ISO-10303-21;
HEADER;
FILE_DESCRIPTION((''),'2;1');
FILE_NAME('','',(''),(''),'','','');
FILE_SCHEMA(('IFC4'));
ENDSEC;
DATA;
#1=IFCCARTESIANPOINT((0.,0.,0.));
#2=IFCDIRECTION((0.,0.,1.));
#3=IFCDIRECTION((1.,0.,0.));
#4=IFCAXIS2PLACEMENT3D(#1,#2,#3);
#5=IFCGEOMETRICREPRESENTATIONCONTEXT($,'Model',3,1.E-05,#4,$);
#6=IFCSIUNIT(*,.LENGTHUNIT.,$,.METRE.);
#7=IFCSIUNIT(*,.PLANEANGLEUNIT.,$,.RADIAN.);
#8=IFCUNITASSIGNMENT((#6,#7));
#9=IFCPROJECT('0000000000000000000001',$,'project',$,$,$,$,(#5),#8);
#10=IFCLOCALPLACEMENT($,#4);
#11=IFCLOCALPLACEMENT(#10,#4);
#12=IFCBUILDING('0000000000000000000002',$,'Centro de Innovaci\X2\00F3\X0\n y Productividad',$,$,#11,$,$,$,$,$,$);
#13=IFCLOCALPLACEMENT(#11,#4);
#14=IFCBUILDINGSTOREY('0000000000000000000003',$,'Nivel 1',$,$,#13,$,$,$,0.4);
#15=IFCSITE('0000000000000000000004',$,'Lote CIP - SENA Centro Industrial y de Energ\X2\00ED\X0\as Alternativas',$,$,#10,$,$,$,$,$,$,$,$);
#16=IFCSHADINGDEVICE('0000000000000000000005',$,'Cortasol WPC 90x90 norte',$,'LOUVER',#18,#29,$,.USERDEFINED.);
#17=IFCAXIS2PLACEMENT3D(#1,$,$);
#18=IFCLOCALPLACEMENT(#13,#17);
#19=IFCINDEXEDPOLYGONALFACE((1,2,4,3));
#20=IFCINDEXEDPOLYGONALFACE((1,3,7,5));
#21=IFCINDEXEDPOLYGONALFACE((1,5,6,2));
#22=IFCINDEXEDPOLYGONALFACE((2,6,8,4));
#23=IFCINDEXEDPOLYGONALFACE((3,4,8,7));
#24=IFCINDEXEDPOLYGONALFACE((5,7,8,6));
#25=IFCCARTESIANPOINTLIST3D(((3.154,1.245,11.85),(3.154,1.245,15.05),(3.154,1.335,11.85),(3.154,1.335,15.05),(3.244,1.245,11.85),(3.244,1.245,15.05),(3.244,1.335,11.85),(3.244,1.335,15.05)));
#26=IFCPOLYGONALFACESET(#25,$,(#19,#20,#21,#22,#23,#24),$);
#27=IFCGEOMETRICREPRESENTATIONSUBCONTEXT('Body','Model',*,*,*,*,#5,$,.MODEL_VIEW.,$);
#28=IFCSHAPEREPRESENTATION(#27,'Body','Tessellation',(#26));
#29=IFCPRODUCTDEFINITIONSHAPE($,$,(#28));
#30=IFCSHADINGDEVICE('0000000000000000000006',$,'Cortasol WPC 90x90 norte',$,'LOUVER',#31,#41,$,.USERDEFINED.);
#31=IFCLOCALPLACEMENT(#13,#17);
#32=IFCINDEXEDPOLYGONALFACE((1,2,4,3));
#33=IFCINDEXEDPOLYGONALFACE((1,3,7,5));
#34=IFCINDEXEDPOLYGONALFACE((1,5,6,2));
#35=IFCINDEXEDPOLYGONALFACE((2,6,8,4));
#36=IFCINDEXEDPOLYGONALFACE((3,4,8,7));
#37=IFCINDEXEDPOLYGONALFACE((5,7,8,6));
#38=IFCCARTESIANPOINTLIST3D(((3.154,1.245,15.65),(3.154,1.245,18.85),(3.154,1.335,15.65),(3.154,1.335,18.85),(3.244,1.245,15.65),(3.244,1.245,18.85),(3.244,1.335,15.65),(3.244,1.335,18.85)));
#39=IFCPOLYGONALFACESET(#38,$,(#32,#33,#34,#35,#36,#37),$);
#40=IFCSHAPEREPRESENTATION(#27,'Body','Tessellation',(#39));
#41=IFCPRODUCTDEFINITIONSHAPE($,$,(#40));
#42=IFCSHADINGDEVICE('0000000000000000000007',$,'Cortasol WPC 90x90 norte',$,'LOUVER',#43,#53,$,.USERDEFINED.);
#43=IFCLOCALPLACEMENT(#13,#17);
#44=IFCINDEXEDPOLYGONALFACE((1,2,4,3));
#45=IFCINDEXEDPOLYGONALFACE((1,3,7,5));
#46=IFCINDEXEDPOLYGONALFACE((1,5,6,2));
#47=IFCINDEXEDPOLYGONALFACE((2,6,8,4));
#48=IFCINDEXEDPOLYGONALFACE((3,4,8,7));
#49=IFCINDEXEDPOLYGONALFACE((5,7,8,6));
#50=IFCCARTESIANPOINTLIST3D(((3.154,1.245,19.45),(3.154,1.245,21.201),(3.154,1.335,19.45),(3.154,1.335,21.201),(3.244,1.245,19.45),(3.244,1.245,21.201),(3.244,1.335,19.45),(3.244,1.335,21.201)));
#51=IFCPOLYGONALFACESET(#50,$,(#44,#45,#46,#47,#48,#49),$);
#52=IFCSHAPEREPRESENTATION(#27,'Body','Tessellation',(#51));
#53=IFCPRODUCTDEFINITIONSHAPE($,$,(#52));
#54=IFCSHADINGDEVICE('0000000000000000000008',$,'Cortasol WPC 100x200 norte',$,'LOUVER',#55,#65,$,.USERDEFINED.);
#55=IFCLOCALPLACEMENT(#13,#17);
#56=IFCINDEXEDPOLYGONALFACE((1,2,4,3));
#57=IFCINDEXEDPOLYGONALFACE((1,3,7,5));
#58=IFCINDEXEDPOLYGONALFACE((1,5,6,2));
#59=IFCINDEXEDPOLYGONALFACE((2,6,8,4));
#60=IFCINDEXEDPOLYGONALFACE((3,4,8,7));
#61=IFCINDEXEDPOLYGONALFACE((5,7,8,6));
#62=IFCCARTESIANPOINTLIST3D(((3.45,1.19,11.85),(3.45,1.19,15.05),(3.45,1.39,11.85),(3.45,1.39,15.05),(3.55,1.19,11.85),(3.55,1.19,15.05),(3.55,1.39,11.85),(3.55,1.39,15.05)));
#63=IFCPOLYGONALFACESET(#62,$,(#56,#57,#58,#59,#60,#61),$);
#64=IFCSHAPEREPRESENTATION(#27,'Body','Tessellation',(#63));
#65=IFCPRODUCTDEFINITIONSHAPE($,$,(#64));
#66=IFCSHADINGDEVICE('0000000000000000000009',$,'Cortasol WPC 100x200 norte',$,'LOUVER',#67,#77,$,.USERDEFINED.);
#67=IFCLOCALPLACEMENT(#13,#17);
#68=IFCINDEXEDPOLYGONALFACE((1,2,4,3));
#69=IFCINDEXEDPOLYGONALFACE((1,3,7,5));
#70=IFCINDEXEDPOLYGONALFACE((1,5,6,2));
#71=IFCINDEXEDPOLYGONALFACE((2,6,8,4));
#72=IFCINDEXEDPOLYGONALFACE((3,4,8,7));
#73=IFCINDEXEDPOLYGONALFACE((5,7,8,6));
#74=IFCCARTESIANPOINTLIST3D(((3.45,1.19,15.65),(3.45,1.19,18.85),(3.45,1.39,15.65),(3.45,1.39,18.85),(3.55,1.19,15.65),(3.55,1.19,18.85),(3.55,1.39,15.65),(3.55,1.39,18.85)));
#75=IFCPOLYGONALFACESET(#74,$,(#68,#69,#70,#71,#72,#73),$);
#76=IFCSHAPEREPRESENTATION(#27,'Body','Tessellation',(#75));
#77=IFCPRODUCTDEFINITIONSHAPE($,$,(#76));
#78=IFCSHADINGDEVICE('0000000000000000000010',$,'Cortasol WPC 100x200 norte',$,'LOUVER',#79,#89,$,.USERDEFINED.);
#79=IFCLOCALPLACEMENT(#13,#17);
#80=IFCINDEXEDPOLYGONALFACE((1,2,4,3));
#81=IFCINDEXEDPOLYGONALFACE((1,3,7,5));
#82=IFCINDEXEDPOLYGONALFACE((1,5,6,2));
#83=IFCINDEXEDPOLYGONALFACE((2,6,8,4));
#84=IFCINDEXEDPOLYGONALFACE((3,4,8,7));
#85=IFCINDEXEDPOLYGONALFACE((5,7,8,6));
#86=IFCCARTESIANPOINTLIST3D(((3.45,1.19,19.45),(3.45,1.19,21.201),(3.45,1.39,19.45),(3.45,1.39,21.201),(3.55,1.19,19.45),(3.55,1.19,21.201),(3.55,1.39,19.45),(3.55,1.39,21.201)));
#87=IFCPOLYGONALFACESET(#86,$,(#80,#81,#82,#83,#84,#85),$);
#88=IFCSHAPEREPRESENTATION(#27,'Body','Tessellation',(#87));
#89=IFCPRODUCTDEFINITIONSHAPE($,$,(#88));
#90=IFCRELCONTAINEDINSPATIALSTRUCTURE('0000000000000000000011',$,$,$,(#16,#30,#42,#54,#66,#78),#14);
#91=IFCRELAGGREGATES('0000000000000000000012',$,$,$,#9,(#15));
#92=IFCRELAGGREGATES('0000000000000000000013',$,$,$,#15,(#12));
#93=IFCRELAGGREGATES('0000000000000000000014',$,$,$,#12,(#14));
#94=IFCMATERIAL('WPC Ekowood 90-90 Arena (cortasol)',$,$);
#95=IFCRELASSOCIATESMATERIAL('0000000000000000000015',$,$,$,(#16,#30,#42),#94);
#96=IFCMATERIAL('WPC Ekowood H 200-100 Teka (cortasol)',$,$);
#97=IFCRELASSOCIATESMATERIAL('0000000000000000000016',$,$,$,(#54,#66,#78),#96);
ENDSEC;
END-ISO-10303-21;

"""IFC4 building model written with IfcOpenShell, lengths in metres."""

from ifc_helpers import new_model, si_unit, frame, origin_with_axes, place, context, subcontext, project, spatial, polyline, outline, extrude, material, element, save


model = new_model("IFC4")

# Units and contexts
model_context = context("Model", 3, precision=1e-05, world=origin_with_axes())
body_context = subcontext(model_context, "Body", "Model", "MODEL_VIEW")
ifc_project = project(units=[si_unit("LENGTHUNIT", "METRE"), si_unit("PLANEANGLEUNIT", "RADIAN")], contexts=[model_context])

# Site, building, storey
site_placement = place(None, origin_with_axes())
site = spatial("IfcSite", under=ifc_project, at=site_placement, Name="Lote CIP - SENA Centro Industrial y de Energías Alternativas")
building_placement = place(site_placement, origin_with_axes())
building = spatial("IfcBuilding", under=site, at=building_placement, Name="Centro de Innovación y Productividad")
storey_placement = place(building_placement, origin_with_axes())
storey = spatial("IfcBuildingStorey", under=building, at=storey_placement, Name="Nivel 1", Elevation=0.4)

# Shading devices
ifc_material_1 = material(Name="WPC Ekowood H 200-100 Teka (cortasol)")
ifc_material_2 = material(Name="WPC Ekowood 90-90 Arena (cortasol)")
shading_device_1_placement = place(storey_placement, origin_with_axes())
element("IfcShadingDevice", 1, at=shading_device_1_placement, inside=storey, material=ifc_material_2, Name="Cortasol WPC 90x90 norte", ObjectType="LOUVER", PredefinedType="USERDEFINED", context=body_context, shape_type="SweptSolid", body=[
    extrude(outline(polyline([(3.154, 1.245), (3.154, 1.335), (3.244, 1.335), (3.244, 1.245), (3.154, 1.245)])), frame((0.0, 0.0, 11.85)), (0.0, 0.0, 1.0), 3.2),
])
shading_device_2_placement = place(storey_placement, origin_with_axes())
element("IfcShadingDevice", 2, at=shading_device_2_placement, inside=storey, material=ifc_material_2, Name="Cortasol WPC 90x90 norte", ObjectType="LOUVER", PredefinedType="USERDEFINED", context=body_context, shape_type="SweptSolid", body=[
    extrude(outline(polyline([(3.154, 1.245), (3.154, 1.335), (3.244, 1.335), (3.244, 1.245), (3.154, 1.245)])), frame((0.0, 0.0, 15.65)), (0.0, 0.0, 1.0), 3.2),
])
shading_device_3_placement = place(storey_placement, origin_with_axes())
element("IfcShadingDevice", 3, at=shading_device_3_placement, inside=storey, material=ifc_material_2, Name="Cortasol WPC 90x90 norte", ObjectType="LOUVER", PredefinedType="USERDEFINED", context=body_context, shape_type="SweptSolid", body=[
    extrude(outline(polyline([(3.154, 1.245), (3.154, 1.335), (3.244, 1.335), (3.244, 1.245), (3.154, 1.245)])), frame((0.0, 0.0, 19.45)), (0.0, 0.0, 1.0), 1.751),
])
shading_device_4_placement = place(storey_placement, origin_with_axes())
element("IfcShadingDevice", 4, at=shading_device_4_placement, inside=storey, material=ifc_material_1, Name="Cortasol WPC 100x200 norte", ObjectType="LOUVER", PredefinedType="USERDEFINED", context=body_context, shape_type="SweptSolid", body=[
    extrude(outline(polyline([(3.45, 1.19), (3.45, 1.39), (3.55, 1.39), (3.55, 1.19), (3.45, 1.19)])), frame((0.0, 0.0, 11.85)), (0.0, 0.0, 1.0), 3.2),
])
shading_device_5_placement = place(storey_placement, origin_with_axes())
element("IfcShadingDevice", 5, at=shading_device_5_placement, inside=storey, material=ifc_material_1, Name="Cortasol WPC 100x200 norte", ObjectType="LOUVER", PredefinedType="USERDEFINED", context=body_context, shape_type="SweptSolid", body=[
    extrude(outline(polyline([(3.45, 1.19), (3.45, 1.39), (3.55, 1.39), (3.55, 1.19), (3.45, 1.19)])), frame((0.0, 0.0, 15.65)), (0.0, 0.0, 1.0), 3.2),
])
shading_device_6_placement = place(storey_placement, origin_with_axes())
element("IfcShadingDevice", 6, at=shading_device_6_placement, inside=storey, material=ifc_material_1, Name="Cortasol WPC 100x200 norte", ObjectType="LOUVER", PredefinedType="USERDEFINED", context=body_context, shape_type="SweptSolid", body=[
    extrude(outline(polyline([(3.45, 1.19), (3.45, 1.39), (3.55, 1.39), (3.55, 1.19), (3.45, 1.19)])), frame((0.0, 0.0, 19.45)), (0.0, 0.0, 1.0), 1.751),
])

save(model, "model.ifc")
